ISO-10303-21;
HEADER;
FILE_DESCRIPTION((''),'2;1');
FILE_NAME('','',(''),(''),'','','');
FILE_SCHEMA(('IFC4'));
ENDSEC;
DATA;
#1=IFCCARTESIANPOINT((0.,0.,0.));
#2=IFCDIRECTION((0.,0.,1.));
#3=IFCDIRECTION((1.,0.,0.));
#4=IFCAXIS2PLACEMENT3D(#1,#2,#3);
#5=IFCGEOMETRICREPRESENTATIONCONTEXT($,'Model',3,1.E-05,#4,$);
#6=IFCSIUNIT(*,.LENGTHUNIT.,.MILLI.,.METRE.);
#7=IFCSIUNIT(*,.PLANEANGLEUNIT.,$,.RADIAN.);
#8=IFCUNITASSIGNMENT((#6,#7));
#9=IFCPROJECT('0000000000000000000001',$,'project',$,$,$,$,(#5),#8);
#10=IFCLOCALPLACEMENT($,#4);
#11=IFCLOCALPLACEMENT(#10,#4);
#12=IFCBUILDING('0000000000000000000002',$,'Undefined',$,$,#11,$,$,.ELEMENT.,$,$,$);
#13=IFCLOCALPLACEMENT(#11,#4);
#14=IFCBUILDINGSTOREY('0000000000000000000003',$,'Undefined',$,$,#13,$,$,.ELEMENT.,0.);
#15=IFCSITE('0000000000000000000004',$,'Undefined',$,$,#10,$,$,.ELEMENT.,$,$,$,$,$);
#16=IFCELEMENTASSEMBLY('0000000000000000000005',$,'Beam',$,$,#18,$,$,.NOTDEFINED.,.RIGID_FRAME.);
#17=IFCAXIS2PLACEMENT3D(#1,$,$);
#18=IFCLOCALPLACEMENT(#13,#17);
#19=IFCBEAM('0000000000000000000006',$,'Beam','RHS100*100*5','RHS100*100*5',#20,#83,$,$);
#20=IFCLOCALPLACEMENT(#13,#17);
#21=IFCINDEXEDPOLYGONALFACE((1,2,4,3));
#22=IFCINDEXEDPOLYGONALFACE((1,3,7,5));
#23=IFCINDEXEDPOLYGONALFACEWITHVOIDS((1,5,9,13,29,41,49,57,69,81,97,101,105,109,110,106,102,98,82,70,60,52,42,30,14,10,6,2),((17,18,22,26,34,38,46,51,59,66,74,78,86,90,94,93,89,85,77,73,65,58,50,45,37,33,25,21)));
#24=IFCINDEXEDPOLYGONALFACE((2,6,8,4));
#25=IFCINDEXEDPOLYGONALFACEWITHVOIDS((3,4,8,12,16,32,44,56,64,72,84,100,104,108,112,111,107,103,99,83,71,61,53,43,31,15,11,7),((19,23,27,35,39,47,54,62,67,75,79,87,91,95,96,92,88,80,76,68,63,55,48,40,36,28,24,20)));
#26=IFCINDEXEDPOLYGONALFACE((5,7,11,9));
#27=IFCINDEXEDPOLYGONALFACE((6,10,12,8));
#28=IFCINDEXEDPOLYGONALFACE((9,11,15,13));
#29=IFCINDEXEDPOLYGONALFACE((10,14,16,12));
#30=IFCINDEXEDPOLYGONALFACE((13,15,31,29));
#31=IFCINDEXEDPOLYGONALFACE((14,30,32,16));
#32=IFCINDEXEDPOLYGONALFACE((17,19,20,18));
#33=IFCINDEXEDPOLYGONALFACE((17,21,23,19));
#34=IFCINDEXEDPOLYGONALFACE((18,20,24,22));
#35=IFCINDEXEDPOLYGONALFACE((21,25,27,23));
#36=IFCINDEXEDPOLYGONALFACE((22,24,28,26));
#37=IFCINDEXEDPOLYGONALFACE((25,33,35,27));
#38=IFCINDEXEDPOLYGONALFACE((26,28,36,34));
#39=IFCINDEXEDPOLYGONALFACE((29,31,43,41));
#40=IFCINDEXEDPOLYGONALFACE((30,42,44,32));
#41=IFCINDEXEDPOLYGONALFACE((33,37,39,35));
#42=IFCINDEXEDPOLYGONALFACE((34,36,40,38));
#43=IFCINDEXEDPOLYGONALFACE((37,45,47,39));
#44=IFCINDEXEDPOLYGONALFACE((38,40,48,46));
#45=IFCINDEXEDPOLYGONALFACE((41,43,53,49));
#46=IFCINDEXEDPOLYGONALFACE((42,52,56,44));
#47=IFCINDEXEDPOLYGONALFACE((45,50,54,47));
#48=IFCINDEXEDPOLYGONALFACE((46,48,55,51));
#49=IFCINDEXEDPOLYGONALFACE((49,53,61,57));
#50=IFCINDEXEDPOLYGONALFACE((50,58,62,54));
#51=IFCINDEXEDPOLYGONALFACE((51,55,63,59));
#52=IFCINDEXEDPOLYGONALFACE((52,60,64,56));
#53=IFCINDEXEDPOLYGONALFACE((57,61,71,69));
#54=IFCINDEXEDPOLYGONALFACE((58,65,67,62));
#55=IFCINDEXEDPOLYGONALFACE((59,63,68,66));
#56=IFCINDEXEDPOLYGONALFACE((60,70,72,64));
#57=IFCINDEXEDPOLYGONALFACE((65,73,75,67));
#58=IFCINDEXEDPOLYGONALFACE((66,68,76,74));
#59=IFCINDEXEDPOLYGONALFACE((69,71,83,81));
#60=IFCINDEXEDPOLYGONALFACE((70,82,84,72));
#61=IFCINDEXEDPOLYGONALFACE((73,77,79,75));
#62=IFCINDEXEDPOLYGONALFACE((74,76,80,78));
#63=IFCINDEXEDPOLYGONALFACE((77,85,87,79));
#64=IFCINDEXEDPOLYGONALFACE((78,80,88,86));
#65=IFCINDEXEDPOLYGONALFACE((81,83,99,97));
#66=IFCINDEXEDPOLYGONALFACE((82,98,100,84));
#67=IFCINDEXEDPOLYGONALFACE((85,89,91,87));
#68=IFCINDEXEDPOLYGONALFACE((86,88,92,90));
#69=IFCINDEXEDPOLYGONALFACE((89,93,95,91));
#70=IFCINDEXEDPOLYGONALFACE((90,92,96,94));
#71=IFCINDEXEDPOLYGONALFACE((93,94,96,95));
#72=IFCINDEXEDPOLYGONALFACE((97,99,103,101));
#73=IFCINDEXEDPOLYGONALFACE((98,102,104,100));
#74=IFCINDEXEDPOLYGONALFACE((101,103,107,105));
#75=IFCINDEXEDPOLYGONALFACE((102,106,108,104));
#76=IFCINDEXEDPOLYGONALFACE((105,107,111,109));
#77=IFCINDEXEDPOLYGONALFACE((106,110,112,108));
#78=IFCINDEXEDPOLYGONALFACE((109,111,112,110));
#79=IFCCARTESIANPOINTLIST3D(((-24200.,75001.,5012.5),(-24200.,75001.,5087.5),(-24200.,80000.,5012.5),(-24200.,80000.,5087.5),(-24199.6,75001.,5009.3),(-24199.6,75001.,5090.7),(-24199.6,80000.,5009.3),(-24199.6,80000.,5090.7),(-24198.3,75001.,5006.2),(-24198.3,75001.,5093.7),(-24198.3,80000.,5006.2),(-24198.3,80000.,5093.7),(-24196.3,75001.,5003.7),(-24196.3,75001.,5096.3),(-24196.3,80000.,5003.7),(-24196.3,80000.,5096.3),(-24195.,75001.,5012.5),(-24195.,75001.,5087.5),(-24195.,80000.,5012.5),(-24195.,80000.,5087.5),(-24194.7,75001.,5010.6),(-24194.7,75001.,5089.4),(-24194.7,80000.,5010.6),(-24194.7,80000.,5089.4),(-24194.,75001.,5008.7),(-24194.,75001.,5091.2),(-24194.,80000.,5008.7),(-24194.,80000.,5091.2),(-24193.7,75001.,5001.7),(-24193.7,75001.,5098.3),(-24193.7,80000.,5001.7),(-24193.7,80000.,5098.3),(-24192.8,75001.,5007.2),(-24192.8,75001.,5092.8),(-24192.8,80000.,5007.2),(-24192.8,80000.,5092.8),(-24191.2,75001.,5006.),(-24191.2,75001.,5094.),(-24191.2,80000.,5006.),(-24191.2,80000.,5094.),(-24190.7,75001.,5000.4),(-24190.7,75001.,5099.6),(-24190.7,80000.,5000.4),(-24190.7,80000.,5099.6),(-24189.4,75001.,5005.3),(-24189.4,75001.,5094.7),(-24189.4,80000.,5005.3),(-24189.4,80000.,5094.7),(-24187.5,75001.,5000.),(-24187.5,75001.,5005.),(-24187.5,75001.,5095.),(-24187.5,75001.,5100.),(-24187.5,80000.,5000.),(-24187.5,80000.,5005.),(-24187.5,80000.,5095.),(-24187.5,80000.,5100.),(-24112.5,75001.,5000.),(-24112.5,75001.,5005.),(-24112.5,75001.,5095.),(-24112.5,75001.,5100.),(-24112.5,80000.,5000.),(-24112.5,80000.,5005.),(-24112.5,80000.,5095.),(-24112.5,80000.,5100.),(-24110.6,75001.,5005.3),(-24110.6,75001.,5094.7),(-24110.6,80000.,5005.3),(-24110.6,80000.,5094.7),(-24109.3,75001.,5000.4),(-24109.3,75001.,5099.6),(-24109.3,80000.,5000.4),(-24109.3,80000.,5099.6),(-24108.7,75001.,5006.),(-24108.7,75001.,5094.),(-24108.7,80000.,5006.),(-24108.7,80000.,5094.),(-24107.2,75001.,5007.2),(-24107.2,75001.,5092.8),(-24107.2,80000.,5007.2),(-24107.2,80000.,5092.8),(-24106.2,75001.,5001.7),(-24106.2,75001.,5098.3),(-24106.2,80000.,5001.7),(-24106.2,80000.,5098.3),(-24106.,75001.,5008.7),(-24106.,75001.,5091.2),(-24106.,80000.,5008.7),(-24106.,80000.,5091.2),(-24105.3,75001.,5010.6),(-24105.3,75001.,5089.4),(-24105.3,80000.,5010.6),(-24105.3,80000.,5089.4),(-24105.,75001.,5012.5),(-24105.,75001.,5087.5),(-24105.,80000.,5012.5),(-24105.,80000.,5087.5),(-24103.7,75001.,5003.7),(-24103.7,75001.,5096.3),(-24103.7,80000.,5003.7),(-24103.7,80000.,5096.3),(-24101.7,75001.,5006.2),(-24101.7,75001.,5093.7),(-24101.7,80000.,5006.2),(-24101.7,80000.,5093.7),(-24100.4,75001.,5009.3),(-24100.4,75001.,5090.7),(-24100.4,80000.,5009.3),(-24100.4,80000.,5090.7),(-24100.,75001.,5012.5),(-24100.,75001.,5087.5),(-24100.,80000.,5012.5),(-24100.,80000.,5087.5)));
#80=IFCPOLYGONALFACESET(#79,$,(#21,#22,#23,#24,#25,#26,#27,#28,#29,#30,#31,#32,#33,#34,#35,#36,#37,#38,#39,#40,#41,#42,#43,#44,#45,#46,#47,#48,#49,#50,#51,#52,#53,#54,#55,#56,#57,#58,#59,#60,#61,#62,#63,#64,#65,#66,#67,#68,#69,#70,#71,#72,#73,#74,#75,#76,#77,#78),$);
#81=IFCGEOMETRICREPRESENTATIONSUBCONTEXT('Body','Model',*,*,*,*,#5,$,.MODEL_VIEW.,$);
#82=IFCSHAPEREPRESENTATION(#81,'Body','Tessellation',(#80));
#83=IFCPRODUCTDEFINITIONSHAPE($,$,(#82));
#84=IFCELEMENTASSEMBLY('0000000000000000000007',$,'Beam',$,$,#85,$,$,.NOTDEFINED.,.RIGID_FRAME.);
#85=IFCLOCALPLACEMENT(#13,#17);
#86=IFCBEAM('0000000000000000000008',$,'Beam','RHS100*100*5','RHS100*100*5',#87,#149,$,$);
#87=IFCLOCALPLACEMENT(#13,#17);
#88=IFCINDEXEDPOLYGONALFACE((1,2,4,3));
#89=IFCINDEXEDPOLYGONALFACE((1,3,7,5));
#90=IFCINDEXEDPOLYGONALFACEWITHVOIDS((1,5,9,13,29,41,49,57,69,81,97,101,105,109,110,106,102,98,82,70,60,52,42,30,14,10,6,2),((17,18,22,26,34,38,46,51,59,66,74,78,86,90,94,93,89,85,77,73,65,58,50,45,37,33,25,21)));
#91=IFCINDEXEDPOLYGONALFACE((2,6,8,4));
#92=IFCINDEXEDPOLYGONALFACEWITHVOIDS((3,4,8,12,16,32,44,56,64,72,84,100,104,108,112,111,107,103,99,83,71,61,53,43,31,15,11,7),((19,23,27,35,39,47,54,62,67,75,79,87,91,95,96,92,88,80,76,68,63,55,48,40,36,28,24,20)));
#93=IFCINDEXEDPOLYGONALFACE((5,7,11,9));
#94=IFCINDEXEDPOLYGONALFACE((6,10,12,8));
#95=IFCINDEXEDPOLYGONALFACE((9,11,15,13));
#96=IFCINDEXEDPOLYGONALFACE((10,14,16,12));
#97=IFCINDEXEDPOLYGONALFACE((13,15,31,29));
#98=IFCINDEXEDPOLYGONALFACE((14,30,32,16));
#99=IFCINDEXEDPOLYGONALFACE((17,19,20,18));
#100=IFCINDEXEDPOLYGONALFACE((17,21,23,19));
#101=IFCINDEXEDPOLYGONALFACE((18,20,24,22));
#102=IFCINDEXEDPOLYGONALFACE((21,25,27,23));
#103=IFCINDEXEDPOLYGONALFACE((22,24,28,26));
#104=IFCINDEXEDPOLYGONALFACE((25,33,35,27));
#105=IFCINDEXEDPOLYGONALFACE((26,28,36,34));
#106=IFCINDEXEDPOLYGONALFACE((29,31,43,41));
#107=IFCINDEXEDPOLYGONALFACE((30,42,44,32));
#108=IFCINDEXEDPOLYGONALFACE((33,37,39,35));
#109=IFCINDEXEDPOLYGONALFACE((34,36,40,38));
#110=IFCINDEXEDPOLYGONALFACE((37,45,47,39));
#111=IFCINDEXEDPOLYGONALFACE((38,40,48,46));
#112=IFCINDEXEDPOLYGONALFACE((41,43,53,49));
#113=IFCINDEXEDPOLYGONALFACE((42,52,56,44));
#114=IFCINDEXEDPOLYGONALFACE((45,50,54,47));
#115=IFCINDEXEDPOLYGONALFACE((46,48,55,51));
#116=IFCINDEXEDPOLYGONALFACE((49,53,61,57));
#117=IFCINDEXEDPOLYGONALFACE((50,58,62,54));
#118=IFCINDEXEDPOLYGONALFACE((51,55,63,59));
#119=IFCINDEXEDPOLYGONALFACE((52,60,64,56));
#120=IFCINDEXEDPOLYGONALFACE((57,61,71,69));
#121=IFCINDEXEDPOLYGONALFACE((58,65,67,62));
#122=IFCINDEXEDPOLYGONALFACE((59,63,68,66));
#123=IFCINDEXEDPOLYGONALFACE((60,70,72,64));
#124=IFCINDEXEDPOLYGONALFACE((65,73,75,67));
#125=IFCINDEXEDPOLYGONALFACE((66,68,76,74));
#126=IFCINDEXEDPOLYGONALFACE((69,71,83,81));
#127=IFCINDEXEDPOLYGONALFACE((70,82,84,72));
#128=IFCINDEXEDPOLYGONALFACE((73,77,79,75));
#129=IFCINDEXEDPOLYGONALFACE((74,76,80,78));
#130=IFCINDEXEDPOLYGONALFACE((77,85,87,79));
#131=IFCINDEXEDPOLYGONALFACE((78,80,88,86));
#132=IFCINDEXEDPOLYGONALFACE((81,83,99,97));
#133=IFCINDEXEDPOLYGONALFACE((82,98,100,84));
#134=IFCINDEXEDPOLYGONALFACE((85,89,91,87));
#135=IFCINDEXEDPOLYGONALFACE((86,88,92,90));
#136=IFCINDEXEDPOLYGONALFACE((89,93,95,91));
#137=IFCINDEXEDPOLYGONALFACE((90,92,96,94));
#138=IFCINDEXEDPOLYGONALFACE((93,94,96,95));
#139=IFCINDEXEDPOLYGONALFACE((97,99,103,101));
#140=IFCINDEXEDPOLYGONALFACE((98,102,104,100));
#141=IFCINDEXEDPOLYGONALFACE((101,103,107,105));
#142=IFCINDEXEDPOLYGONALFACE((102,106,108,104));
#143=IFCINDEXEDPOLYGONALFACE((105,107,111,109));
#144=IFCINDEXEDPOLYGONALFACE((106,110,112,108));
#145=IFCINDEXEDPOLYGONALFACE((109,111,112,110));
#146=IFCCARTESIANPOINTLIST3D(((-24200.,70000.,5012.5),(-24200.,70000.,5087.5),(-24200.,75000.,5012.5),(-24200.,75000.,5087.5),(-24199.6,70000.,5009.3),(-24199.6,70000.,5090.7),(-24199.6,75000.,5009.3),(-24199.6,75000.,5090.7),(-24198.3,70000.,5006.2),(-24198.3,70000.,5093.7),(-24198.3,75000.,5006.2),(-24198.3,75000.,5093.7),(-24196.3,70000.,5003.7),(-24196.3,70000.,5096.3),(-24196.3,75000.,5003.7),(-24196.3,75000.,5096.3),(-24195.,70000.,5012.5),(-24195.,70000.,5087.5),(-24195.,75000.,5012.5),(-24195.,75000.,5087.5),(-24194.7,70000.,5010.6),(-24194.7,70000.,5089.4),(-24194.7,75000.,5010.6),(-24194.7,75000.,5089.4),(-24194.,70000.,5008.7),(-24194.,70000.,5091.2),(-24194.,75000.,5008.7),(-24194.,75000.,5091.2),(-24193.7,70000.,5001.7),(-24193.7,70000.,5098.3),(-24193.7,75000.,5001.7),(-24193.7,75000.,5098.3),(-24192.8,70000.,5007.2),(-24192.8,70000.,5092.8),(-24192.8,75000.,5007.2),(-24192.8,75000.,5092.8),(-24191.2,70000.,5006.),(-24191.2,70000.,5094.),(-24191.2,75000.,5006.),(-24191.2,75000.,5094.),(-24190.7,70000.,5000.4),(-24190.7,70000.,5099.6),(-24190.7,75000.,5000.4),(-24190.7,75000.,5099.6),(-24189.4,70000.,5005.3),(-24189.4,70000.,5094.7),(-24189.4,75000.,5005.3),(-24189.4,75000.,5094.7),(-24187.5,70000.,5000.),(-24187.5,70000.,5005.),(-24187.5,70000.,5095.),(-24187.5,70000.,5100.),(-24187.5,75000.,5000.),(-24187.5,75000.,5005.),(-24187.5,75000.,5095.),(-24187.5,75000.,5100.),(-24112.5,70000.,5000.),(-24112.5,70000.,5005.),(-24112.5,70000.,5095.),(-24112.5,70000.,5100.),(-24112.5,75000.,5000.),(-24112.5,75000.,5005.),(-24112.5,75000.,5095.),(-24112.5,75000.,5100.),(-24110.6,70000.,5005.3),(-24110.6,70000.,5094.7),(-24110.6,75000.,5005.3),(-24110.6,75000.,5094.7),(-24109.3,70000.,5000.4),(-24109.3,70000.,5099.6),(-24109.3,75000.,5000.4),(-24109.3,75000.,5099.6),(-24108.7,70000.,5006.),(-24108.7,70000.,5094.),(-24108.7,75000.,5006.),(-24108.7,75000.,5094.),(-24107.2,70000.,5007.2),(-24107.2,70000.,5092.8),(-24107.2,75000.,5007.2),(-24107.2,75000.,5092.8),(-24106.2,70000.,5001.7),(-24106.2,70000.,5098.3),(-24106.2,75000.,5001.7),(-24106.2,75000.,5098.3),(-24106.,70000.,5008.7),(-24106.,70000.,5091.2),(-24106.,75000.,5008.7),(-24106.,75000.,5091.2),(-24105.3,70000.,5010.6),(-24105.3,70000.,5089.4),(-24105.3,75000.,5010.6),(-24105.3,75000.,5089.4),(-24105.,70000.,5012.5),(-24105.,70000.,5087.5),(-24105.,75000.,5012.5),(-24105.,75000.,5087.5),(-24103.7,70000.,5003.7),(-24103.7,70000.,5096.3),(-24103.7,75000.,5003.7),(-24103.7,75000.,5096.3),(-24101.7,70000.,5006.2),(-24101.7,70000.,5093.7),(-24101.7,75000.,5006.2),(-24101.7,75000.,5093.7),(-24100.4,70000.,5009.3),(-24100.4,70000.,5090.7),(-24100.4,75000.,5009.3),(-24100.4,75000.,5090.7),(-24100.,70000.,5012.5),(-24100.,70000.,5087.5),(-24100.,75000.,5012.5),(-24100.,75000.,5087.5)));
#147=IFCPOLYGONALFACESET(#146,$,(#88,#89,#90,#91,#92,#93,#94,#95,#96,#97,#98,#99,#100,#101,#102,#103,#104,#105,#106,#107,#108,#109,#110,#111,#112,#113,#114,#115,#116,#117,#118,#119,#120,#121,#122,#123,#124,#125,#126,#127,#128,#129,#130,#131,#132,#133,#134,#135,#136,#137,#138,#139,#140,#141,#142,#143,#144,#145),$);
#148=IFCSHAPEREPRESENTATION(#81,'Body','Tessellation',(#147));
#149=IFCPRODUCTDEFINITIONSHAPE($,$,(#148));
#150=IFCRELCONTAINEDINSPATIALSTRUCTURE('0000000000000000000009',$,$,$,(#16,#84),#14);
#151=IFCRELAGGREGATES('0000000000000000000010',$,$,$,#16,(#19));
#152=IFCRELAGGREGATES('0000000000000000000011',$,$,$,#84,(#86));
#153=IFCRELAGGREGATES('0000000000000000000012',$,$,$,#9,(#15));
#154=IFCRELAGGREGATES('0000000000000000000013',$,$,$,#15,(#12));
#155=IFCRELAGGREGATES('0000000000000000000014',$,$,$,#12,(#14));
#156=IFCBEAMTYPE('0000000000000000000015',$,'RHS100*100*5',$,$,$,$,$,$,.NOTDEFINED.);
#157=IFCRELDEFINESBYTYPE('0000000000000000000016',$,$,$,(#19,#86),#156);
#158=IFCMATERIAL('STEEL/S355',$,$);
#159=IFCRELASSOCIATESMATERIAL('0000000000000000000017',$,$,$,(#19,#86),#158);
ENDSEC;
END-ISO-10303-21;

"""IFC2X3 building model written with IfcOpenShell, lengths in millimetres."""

from ifc_helpers import new_model, si_unit, frame, origin_with_axes, origin_2d_with_axis, place, context, subcontext, project, spatial, hollow_rectangle, extrude, material, type_object, element, aggregate, save


model = new_model("IFC2X3")

# Units and contexts
model_context = context("Model", 3, precision=1e-05, world=origin_with_axes())
body_context = subcontext(model_context, "Body", "Model", "MODEL_VIEW")
ifc_project = project(units=[si_unit("LENGTHUNIT", "METRE", prefix="MILLI"), si_unit("PLANEANGLEUNIT", "RADIAN")], contexts=[model_context])

# Site, building, storey
site_placement = place(None, origin_with_axes())
site = spatial("IfcSite", under=ifc_project, at=site_placement, Name="Undefined", CompositionType="ELEMENT")
building_placement = place(site_placement, origin_with_axes())
building = spatial("IfcBuilding", under=site, at=building_placement, Name="Undefined", CompositionType="ELEMENT")
storey_placement = place(building_placement, origin_with_axes())
storey = spatial("IfcBuildingStorey", under=building, at=storey_placement, Name="Undefined", CompositionType="ELEMENT", Elevation=0.0)

# Element assemblies, beams
ifc_material_1 = material(Name="STEEL/S355")
beam_type_1 = type_object("IfcBeamType", Name="RHS100*100*5", PredefinedType="NOTDEFINED")
assembly_1_placement = place(storey_placement, origin_with_axes())
assembly_1 = element("IfcElementAssembly", 1, at=assembly_1_placement, inside=storey, Name="Beam", AssemblyPlace="NOTDEFINED", PredefinedType="RIGID_FRAME")
beam_1_placement = place(assembly_1_placement, frame((-24150.0, 75001.0, 5050.0), z_axis=(0.0, 0.0, 1.0), x_axis=(0.0, 1.0, 0.0)))
beam_1 = element("IfcBeam", 2, at=beam_1_placement, type_object=beam_type_1, material=ifc_material_1, Name="Beam", Description="RHS100*100*5", ObjectType="RHS100*100*5", context=body_context, shape_type="SweptSolid", body=[
    extrude(hollow_rectangle(XDim=100.0, YDim=100.0, WallThickness=5.0, InnerFilletRadius=7.5, OuterFilletRadius=12.5, at=origin_2d_with_axis()), frame((4999.0, 0.0, 0.0), z_axis=(-1.0, 0.0, 0.0), x_axis=(0.0, -1.0, 0.0)), (0.0, 0.0, 1.0), 4999.0),
])
aggregate(assembly_1, [beam_1])
assembly_2_placement = place(storey_placement, origin_with_axes())
assembly_2 = element("IfcElementAssembly", 3, at=assembly_2_placement, inside=storey, Name="Beam", AssemblyPlace="NOTDEFINED", PredefinedType="RIGID_FRAME")
beam_2_placement = place(assembly_2_placement, frame((-24150.0, 70000.0, 5050.0), z_axis=(0.0, 0.0, 1.0), x_axis=(0.0, 1.0, 0.0)))
beam_2 = element("IfcBeam", 4, at=beam_2_placement, type_object=beam_type_1, material=ifc_material_1, Name="Beam", Description="RHS100*100*5", ObjectType="RHS100*100*5", context=body_context, shape_type="SweptSolid", body=[
    extrude(hollow_rectangle(XDim=100.0, YDim=100.0, WallThickness=5.0, InnerFilletRadius=7.5, OuterFilletRadius=12.5, at=origin_2d_with_axis()), frame((5000.0, 0.0, 0.0), z_axis=(-1.0, 0.0, 0.0), x_axis=(0.0, -1.0, 0.0)), (0.0, 0.0, 1.0), 5000.0),
])
aggregate(assembly_2, [beam_2])

save(model, "model.ifc")
